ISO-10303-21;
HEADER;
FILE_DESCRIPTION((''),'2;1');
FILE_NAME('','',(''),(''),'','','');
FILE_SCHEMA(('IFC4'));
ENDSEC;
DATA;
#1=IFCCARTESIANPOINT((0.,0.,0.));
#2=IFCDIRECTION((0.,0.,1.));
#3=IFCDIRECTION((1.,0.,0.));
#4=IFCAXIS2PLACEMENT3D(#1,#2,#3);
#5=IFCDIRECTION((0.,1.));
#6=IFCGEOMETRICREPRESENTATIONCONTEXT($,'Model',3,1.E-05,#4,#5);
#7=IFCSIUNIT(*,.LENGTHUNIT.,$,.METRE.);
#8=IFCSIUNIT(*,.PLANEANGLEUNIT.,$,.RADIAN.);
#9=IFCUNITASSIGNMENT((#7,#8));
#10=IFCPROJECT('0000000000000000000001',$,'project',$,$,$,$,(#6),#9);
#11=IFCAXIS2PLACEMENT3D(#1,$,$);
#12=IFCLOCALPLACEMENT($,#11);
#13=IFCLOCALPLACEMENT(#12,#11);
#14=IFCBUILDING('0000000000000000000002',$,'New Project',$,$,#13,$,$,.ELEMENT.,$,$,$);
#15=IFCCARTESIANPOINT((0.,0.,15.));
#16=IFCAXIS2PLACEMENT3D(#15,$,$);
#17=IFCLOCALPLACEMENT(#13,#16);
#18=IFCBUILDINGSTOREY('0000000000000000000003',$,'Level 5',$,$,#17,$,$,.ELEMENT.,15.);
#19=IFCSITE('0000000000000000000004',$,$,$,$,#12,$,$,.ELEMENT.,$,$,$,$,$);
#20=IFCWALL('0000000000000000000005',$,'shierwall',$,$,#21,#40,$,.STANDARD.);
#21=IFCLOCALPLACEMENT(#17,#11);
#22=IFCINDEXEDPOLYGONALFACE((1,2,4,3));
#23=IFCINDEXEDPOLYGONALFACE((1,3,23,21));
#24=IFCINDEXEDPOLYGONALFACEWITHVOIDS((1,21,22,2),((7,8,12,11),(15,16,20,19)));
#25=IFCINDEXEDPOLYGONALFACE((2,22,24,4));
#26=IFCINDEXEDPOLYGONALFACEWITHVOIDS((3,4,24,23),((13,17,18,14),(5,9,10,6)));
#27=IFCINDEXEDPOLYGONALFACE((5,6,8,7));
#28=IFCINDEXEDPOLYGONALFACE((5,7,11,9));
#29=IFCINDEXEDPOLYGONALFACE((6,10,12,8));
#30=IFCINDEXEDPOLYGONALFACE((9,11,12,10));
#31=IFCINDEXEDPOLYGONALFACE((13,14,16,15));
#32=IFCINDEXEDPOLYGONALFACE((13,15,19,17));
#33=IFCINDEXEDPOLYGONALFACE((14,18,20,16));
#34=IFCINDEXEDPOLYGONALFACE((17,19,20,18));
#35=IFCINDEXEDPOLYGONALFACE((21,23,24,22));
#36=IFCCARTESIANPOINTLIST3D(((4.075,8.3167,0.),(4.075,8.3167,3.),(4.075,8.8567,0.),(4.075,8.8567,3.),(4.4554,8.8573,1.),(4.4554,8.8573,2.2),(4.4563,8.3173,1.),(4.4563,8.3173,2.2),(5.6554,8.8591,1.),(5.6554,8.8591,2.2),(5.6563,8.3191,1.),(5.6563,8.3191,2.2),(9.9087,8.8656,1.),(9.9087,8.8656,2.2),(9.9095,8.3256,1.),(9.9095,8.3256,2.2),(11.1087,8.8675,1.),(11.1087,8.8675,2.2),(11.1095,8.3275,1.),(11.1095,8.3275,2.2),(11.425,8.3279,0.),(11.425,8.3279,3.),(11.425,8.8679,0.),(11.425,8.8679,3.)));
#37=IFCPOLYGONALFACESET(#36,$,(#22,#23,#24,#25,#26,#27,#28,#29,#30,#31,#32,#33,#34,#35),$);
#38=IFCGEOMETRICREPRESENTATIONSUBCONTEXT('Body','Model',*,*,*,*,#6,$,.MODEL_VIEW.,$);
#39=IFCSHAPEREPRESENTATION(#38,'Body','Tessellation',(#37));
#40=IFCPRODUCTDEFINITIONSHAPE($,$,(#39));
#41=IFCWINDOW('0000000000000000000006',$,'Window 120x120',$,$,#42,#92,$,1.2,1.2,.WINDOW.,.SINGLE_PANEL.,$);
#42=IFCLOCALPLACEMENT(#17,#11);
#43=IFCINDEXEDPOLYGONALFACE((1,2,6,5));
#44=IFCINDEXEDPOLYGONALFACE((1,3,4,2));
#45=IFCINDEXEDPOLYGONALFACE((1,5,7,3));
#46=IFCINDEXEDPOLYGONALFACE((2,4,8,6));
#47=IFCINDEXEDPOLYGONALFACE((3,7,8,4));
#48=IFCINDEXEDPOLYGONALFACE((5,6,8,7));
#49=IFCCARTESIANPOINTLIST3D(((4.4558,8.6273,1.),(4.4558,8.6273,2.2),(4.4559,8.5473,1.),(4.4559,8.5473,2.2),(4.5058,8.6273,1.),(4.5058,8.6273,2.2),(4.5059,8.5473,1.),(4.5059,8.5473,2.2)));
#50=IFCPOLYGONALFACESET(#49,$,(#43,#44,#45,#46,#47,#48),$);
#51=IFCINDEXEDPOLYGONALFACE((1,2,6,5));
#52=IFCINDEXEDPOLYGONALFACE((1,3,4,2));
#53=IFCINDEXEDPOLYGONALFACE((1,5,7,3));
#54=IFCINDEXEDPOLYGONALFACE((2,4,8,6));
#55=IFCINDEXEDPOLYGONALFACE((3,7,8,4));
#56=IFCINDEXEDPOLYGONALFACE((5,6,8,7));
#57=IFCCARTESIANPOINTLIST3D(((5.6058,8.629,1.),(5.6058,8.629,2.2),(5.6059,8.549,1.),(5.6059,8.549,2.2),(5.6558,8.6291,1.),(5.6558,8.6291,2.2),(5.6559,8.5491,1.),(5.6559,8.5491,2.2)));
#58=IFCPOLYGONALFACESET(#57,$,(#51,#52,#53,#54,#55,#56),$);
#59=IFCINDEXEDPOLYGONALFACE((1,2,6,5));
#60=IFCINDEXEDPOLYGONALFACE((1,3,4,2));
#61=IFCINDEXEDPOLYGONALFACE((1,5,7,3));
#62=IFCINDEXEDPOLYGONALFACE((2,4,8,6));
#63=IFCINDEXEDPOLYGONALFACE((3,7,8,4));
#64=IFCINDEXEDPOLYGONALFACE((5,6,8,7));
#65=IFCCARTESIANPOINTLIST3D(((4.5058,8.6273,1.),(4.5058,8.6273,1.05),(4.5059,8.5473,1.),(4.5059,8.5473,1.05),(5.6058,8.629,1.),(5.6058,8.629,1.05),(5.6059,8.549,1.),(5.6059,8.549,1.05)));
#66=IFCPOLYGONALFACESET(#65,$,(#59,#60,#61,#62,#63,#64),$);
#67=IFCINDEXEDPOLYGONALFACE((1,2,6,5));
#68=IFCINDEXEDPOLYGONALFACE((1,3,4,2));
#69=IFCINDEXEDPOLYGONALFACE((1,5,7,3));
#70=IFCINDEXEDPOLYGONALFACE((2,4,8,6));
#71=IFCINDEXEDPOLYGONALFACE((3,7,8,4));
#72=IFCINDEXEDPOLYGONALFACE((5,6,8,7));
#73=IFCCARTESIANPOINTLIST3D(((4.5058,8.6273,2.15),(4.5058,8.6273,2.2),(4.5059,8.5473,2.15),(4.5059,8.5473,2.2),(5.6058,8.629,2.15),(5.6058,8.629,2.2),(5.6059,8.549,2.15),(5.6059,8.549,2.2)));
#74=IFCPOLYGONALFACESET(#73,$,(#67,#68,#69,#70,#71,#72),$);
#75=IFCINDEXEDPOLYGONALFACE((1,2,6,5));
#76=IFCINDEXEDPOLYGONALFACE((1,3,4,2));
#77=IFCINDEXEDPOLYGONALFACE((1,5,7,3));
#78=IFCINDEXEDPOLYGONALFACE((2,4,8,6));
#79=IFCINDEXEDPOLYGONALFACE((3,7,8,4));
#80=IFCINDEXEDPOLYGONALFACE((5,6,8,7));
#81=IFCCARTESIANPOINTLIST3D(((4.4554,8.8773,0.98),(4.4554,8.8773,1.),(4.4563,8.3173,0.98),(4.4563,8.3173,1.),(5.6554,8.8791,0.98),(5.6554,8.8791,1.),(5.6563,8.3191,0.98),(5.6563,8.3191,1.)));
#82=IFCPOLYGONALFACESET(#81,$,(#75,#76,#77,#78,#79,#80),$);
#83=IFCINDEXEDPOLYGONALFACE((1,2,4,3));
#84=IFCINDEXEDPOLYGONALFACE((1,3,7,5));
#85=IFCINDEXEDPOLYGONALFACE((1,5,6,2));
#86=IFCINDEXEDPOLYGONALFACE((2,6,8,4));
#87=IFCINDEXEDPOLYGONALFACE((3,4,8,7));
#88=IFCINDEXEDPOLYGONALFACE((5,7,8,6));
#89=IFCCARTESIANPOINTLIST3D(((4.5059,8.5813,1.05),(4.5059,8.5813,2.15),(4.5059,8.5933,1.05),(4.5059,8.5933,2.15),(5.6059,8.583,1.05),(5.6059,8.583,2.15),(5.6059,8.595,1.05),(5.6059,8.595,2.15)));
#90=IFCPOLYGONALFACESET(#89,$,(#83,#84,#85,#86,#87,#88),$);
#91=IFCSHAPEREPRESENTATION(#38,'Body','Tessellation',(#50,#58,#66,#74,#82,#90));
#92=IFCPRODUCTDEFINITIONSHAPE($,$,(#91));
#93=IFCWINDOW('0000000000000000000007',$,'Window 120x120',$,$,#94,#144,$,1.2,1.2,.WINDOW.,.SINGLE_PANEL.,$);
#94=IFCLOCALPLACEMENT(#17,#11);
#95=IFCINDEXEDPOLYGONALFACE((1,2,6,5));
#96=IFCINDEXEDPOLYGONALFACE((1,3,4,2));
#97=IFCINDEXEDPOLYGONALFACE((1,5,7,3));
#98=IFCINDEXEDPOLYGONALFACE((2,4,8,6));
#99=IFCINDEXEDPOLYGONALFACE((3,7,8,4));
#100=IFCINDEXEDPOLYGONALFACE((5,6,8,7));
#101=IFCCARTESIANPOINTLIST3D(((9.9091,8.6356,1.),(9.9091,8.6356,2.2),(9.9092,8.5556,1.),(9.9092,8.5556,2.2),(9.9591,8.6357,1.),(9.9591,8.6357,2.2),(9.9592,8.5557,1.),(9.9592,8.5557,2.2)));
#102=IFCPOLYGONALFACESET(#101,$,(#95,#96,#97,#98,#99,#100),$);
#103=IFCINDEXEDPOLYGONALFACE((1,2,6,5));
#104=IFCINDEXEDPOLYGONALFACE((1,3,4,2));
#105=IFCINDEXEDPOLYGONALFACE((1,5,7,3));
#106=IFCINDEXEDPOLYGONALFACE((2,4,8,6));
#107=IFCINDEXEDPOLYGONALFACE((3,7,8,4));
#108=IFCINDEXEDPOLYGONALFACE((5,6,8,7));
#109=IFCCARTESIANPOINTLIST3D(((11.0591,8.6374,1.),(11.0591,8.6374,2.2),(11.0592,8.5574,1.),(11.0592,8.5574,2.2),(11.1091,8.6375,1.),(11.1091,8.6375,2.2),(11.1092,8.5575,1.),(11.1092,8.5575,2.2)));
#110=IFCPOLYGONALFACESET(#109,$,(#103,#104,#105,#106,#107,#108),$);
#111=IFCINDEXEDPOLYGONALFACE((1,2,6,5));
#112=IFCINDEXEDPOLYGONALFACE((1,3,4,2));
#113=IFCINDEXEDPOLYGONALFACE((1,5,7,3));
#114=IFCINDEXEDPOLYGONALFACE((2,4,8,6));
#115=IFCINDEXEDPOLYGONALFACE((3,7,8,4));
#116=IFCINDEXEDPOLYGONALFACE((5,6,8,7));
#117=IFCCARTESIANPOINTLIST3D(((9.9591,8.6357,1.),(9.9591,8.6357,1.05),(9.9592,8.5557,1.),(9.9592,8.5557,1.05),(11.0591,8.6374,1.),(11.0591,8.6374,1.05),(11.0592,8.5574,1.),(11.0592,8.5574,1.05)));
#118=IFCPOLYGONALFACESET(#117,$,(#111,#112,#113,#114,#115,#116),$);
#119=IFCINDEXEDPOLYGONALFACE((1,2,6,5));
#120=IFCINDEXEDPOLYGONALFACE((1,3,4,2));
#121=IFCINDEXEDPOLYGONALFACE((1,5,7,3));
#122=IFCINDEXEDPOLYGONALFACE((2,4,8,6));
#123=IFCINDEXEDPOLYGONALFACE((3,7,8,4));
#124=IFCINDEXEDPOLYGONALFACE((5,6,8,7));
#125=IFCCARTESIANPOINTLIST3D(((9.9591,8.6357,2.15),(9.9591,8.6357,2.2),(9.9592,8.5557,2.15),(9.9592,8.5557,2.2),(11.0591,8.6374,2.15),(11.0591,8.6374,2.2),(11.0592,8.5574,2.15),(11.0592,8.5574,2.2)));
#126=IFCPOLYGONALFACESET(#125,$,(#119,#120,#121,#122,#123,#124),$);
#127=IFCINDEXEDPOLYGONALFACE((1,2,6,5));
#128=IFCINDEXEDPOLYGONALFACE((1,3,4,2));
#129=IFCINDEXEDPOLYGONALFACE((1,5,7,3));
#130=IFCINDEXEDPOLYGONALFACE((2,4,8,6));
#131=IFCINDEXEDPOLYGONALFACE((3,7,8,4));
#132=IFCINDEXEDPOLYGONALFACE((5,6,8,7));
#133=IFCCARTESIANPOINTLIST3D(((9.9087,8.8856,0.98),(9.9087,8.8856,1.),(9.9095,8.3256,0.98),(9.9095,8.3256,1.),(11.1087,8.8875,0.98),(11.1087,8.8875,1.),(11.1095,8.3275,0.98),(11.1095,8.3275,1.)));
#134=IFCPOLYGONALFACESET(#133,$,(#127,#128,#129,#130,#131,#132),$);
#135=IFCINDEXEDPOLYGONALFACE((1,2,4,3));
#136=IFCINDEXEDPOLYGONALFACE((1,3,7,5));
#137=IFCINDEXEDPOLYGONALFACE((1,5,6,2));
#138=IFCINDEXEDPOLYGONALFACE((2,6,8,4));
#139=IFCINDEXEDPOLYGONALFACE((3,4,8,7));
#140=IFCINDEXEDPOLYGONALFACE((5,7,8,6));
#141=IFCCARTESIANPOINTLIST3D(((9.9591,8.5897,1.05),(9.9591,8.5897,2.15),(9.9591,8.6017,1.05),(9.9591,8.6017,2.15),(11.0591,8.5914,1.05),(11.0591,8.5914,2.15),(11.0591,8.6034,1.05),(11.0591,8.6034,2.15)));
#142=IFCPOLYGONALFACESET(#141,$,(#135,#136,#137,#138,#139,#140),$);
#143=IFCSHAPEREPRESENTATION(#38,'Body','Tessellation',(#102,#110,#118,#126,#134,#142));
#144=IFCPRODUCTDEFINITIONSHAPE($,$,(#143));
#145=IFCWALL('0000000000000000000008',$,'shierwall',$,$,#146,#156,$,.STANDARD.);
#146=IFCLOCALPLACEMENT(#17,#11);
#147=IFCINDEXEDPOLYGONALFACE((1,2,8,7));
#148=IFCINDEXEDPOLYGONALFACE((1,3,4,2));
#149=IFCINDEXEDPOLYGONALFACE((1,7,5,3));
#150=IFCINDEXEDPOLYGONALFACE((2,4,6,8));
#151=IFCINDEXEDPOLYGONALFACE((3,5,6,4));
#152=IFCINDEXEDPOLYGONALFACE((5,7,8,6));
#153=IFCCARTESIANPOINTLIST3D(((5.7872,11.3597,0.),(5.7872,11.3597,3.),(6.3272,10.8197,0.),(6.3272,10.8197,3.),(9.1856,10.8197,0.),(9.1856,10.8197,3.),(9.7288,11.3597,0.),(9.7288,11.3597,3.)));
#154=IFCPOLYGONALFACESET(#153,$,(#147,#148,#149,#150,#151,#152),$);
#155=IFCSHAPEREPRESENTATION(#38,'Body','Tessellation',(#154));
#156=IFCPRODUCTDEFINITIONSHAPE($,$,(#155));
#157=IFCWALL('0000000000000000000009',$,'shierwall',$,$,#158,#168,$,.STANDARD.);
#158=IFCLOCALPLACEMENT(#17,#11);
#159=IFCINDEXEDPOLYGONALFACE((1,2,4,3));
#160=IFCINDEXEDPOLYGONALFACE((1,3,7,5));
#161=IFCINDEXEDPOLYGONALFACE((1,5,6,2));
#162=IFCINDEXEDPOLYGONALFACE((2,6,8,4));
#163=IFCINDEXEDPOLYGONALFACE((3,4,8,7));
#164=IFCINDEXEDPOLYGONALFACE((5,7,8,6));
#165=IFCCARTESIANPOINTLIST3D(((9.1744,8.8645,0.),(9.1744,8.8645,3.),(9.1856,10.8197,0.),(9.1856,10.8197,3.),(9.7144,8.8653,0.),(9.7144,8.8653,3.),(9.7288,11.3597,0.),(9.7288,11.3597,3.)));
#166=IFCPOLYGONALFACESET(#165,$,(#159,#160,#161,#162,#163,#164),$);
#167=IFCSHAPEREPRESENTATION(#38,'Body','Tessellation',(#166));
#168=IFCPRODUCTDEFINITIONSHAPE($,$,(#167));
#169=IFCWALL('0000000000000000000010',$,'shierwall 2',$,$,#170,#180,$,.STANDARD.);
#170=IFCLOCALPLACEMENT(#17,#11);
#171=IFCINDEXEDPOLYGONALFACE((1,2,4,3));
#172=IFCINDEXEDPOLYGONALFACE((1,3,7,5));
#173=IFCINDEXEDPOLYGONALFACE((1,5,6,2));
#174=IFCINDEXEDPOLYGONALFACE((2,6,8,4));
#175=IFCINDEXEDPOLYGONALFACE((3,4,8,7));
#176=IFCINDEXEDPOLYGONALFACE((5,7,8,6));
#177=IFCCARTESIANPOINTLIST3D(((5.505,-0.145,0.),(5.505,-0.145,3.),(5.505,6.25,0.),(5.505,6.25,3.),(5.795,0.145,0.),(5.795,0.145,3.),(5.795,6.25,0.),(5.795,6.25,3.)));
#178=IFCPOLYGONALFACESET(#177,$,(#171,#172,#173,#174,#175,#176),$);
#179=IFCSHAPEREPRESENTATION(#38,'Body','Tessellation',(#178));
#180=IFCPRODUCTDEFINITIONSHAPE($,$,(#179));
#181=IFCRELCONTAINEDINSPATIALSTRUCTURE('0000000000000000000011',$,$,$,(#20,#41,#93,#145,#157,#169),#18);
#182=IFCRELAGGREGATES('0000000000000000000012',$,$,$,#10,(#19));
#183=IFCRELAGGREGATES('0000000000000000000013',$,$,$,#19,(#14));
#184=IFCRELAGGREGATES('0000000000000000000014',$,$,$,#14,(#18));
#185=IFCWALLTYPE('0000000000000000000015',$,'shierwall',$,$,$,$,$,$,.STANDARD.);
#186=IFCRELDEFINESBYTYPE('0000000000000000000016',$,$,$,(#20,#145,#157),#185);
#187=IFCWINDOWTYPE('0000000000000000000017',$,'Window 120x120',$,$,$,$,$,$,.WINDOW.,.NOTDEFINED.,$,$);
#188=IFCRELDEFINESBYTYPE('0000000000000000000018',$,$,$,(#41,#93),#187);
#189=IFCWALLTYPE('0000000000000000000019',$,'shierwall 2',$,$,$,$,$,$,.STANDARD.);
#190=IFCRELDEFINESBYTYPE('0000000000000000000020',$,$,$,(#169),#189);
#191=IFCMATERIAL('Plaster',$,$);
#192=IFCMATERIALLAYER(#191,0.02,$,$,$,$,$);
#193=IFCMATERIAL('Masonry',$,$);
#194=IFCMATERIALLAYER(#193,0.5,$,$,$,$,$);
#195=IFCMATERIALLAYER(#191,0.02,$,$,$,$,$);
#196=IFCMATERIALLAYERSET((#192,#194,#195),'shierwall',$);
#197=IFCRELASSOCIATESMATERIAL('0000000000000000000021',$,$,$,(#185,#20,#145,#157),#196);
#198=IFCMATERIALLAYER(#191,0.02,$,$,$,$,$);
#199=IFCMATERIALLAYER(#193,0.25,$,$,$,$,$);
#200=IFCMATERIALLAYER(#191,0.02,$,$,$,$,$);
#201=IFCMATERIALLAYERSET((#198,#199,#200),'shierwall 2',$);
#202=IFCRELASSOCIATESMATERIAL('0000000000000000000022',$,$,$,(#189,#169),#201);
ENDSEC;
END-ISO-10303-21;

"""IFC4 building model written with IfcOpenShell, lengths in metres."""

from ifc_helpers import new_model, si_unit, direction, frame, frame_2d, origin, origin_with_axes, place, context, subcontext, project, spatial, polyline, rectangle, outline, extrude, material, layer, layer_set, layer_usage, type_object, element, fill, save


model = new_model("IFC4")

# Units and contexts
model_context = context("Model", 3, precision=1e-05, world=origin_with_axes(), true_north=direction((0.0, 1.0)))
body_context = subcontext(model_context, "Body", "Model", "MODEL_VIEW")
ifc_project = project(units=[si_unit("LENGTHUNIT", "METRE"), si_unit("PLANEANGLEUNIT", "RADIAN")], contexts=[model_context])

# Site, building, storey
site_placement = place(None, origin())
site = spatial("IfcSite", under=ifc_project, at=site_placement, CompositionType="ELEMENT")
building_placement = place(site_placement, origin())
building = spatial("IfcBuilding", under=site, at=building_placement, Name="New Project", CompositionType="ELEMENT")
storey_placement = place(building_placement, frame((0.0, 0.0, 15.0)))
storey = spatial("IfcBuildingStorey", under=building, at=storey_placement, Name="Level 5", CompositionType="ELEMENT", Elevation=15.0)

# Shared definitions
ifc_material_1 = material(Name="Plaster")
ifc_material_2 = material(Name="Masonry")
window_type = type_object("IfcWindowType", Name="Window 120x120", PartitioningType="NOTDEFINED", PredefinedType="WINDOW")

# Wall, openings, windows
ifc_layer_1 = layer(ifc_material_1, 0.02)
ifc_layer_2 = layer(ifc_material_2, 0.5)
ifc_layer_3 = layer(ifc_material_1, 0.02)
ifc_layer_set_1 = layer_set([ifc_layer_1, ifc_layer_2, ifc_layer_3], Name="shierwall")
ifc_layer_usage_1 = layer_usage(ifc_layer_set_1, "AXIS2", "NEGATIVE", 0.27)
wall_type_1 = type_object("IfcWallType", Name="shierwall", PredefinedType="STANDARD", material=ifc_layer_set_1)
wall_1_placement = place(storey_placement, frame((4.075, 8.5867, 0.0), z_axis=(0.0, 0.0, 1.0), x_axis=(0.999999, 0.001534, 0.0)))
wall_1 = element("IfcWall", 1, at=wall_1_placement, inside=storey, type_object=wall_type_1, material=ifc_layer_usage_1, Name="shierwall", PredefinedType="STANDARD", context=body_context, shape_type="SweptSolid", body=[
    extrude(outline(polyline([(-0.0004, -0.27), (7.3496, -0.27), (7.3504, 0.27), (0.0004, 0.27), (-0.0004, -0.27)])), origin(), (0.0, 0.0, 1.0), 3.0),
])
opening_1_placement = place(wall_1_placement, frame((0.3809, 0.0, 1.0)))
opening_1 = element("IfcOpeningElement", 2, at=opening_1_placement, cuts=wall_1, PredefinedType="OPENING", context=body_context, shape_type="SweptSolid", body=[
    extrude(rectangle(XDim=1.2, YDim=0.64, at=frame_2d((0.6, 0.0))), origin(), (0.0, 0.0, 1.0), 1.2),
])
opening_2_placement = place(wall_1_placement, frame((5.8341, 0.0, 1.0)))
opening_2 = element("IfcOpeningElement", 3, at=opening_2_placement, cuts=wall_1, PredefinedType="OPENING", context=body_context, shape_type="SweptSolid", body=[
    extrude(rectangle(XDim=1.2, YDim=0.64, at=frame_2d((0.6, 0.0))), origin(), (0.0, 0.0, 1.0), 1.2),
])
window_1_placement = place(opening_1_placement, origin())
window_1 = element("IfcWindow", 4, at=window_1_placement, inside=storey, type_object=window_type, Name="Window 120x120", OverallHeight=1.2, OverallWidth=1.2, PartitioningType="SINGLE_PANEL", PredefinedType="WINDOW", context=body_context, shape_type="SweptSolid", body=[
    extrude(outline(polyline([(0.0, -0.04), (0.05, -0.04), (0.05, 0.04), (0.0, 0.04), (0.0, -0.04)])), origin(), (0.0, 0.0, 1.0), 1.2),
    extrude(outline(polyline([(1.15, -0.04), (1.2, -0.04), (1.2, 0.04), (1.15, 0.04), (1.15, -0.04)])), origin(), (0.0, 0.0, 1.0), 1.2),
    extrude(outline(polyline([(0.05, -0.04), (1.15, -0.04), (1.15, 0.04), (0.05, 0.04), (0.05, -0.04)])), origin(), (0.0, 0.0, 1.0), 0.05),
    extrude(outline(polyline([(0.05, -0.04), (1.15, -0.04), (1.15, 0.04), (0.05, 0.04), (0.05, -0.04)])), frame((0.0, 0.0, 1.15)), (0.0, 0.0, 1.0), 0.05),
    extrude(outline(polyline([(0.0, -0.27), (1.2, -0.27), (1.2, 0.29), (0.0, 0.29), (0.0, -0.27)])), frame((0.0, 0.0, -0.02)), (0.0, 0.0, 1.0), 0.02),
    extrude(outline(polyline([(0.05, -0.006), (1.15, -0.006), (1.15, 0.006), (0.05, 0.006), (0.05, -0.006)])), frame((0.0, 0.0, 0.05)), (0.0, 0.0, 1.0), 1.1),
])
fill(opening_1, window_1)
window_2_placement = place(opening_2_placement, origin())
window_2 = element("IfcWindow", 5, at=window_2_placement, inside=storey, type_object=window_type, Name="Window 120x120", OverallHeight=1.2, OverallWidth=1.2, PartitioningType="SINGLE_PANEL", PredefinedType="WINDOW", context=body_context, shape_type="SweptSolid", body=[
    extrude(outline(polyline([(0.0, -0.04), (0.05, -0.04), (0.05, 0.04), (0.0, 0.04), (0.0, -0.04)])), origin(), (0.0, 0.0, 1.0), 1.2),
    extrude(outline(polyline([(1.15, -0.04), (1.2, -0.04), (1.2, 0.04), (1.15, 0.04), (1.15, -0.04)])), origin(), (0.0, 0.0, 1.0), 1.2),
    extrude(outline(polyline([(0.05, -0.04), (1.15, -0.04), (1.15, 0.04), (0.05, 0.04), (0.05, -0.04)])), origin(), (0.0, 0.0, 1.0), 0.05),
    extrude(outline(polyline([(0.05, -0.04), (1.15, -0.04), (1.15, 0.04), (0.05, 0.04), (0.05, -0.04)])), frame((0.0, 0.0, 1.15)), (0.0, 0.0, 1.0), 0.05),
    extrude(outline(polyline([(0.0, -0.27), (1.2, -0.27), (1.2, 0.29), (0.0, 0.29), (0.0, -0.27)])), frame((0.0, 0.0, -0.02)), (0.0, 0.0, 1.0), 0.02),
    extrude(outline(polyline([(0.05, -0.006), (1.15, -0.006), (1.15, 0.006), (0.05, 0.006), (0.05, -0.006)])), frame((0.0, 0.0, 0.05)), (0.0, 0.0, 1.0), 1.1),
])
fill(opening_2, window_2)

# Walls
wall_2_placement = place(storey_placement, frame((6.0572, 11.0897, 0.0)))
element("IfcWall", 6, at=wall_2_placement, inside=storey, type_object=wall_type_1, material=ifc_layer_usage_1, Name="shierwall", PredefinedType="STANDARD", context=body_context, shape_type="SweptSolid", body=[
    extrude(outline(polyline([(0.27, -0.27), (3.1284, -0.27), (3.6716, 0.27), (-0.27, 0.27), (0.27, -0.27)])), origin(), (0.0, 0.0, 1.0), 3.0),
])
wall_3_placement = place(storey_placement, frame((9.4572, 11.0897, 0.0), z_axis=(0.0, 0.0, 1.0), x_axis=(-0.005766, -0.999983, 0.0)))
element("IfcWall", 7, at=wall_3_placement, inside=storey, type_object=wall_type_1, material=ifc_layer_usage_1, Name="shierwall", PredefinedType="STANDARD", context=body_context, shape_type="SweptSolid", body=[
    extrude(outline(polyline([(0.2716, -0.27), (2.2268, -0.27), (2.2229, 0.27), (-0.2716, 0.27), (0.2716, -0.27)])), origin(), (0.0, 0.0, 1.0), 3.0),
])
ifc_layer_4 = layer(ifc_material_1, 0.02)
ifc_layer_5 = layer(ifc_material_2, 0.25)
ifc_layer_6 = layer(ifc_material_1, 0.02)
ifc_layer_set_2 = layer_set([ifc_layer_4, ifc_layer_5, ifc_layer_6], Name="shierwall 2")
ifc_layer_usage_2 = layer_usage(ifc_layer_set_2, "AXIS2", "NEGATIVE", 0.145)
wall_type_2 = type_object("IfcWallType", Name="shierwall 2", PredefinedType="STANDARD", material=ifc_layer_set_2)
wall_4_placement = place(storey_placement, frame((5.65, 6.25, 0.0), z_axis=(0.0, 0.0, 1.0), x_axis=(0.0, -1.0, 0.0)))
element("IfcWall", 8, at=wall_4_placement, inside=storey, type_object=wall_type_2, material=ifc_layer_usage_2, Name="shierwall 2", PredefinedType="STANDARD", context=body_context, shape_type="SweptSolid", body=[
    extrude(outline(polyline([(0.0, -0.145), (6.395, -0.145), (6.105, 0.145), (0.0, 0.145), (0.0, -0.145)])), origin(), (0.0, 0.0, 1.0), 3.0),
])

save(model, "model.ifc")
